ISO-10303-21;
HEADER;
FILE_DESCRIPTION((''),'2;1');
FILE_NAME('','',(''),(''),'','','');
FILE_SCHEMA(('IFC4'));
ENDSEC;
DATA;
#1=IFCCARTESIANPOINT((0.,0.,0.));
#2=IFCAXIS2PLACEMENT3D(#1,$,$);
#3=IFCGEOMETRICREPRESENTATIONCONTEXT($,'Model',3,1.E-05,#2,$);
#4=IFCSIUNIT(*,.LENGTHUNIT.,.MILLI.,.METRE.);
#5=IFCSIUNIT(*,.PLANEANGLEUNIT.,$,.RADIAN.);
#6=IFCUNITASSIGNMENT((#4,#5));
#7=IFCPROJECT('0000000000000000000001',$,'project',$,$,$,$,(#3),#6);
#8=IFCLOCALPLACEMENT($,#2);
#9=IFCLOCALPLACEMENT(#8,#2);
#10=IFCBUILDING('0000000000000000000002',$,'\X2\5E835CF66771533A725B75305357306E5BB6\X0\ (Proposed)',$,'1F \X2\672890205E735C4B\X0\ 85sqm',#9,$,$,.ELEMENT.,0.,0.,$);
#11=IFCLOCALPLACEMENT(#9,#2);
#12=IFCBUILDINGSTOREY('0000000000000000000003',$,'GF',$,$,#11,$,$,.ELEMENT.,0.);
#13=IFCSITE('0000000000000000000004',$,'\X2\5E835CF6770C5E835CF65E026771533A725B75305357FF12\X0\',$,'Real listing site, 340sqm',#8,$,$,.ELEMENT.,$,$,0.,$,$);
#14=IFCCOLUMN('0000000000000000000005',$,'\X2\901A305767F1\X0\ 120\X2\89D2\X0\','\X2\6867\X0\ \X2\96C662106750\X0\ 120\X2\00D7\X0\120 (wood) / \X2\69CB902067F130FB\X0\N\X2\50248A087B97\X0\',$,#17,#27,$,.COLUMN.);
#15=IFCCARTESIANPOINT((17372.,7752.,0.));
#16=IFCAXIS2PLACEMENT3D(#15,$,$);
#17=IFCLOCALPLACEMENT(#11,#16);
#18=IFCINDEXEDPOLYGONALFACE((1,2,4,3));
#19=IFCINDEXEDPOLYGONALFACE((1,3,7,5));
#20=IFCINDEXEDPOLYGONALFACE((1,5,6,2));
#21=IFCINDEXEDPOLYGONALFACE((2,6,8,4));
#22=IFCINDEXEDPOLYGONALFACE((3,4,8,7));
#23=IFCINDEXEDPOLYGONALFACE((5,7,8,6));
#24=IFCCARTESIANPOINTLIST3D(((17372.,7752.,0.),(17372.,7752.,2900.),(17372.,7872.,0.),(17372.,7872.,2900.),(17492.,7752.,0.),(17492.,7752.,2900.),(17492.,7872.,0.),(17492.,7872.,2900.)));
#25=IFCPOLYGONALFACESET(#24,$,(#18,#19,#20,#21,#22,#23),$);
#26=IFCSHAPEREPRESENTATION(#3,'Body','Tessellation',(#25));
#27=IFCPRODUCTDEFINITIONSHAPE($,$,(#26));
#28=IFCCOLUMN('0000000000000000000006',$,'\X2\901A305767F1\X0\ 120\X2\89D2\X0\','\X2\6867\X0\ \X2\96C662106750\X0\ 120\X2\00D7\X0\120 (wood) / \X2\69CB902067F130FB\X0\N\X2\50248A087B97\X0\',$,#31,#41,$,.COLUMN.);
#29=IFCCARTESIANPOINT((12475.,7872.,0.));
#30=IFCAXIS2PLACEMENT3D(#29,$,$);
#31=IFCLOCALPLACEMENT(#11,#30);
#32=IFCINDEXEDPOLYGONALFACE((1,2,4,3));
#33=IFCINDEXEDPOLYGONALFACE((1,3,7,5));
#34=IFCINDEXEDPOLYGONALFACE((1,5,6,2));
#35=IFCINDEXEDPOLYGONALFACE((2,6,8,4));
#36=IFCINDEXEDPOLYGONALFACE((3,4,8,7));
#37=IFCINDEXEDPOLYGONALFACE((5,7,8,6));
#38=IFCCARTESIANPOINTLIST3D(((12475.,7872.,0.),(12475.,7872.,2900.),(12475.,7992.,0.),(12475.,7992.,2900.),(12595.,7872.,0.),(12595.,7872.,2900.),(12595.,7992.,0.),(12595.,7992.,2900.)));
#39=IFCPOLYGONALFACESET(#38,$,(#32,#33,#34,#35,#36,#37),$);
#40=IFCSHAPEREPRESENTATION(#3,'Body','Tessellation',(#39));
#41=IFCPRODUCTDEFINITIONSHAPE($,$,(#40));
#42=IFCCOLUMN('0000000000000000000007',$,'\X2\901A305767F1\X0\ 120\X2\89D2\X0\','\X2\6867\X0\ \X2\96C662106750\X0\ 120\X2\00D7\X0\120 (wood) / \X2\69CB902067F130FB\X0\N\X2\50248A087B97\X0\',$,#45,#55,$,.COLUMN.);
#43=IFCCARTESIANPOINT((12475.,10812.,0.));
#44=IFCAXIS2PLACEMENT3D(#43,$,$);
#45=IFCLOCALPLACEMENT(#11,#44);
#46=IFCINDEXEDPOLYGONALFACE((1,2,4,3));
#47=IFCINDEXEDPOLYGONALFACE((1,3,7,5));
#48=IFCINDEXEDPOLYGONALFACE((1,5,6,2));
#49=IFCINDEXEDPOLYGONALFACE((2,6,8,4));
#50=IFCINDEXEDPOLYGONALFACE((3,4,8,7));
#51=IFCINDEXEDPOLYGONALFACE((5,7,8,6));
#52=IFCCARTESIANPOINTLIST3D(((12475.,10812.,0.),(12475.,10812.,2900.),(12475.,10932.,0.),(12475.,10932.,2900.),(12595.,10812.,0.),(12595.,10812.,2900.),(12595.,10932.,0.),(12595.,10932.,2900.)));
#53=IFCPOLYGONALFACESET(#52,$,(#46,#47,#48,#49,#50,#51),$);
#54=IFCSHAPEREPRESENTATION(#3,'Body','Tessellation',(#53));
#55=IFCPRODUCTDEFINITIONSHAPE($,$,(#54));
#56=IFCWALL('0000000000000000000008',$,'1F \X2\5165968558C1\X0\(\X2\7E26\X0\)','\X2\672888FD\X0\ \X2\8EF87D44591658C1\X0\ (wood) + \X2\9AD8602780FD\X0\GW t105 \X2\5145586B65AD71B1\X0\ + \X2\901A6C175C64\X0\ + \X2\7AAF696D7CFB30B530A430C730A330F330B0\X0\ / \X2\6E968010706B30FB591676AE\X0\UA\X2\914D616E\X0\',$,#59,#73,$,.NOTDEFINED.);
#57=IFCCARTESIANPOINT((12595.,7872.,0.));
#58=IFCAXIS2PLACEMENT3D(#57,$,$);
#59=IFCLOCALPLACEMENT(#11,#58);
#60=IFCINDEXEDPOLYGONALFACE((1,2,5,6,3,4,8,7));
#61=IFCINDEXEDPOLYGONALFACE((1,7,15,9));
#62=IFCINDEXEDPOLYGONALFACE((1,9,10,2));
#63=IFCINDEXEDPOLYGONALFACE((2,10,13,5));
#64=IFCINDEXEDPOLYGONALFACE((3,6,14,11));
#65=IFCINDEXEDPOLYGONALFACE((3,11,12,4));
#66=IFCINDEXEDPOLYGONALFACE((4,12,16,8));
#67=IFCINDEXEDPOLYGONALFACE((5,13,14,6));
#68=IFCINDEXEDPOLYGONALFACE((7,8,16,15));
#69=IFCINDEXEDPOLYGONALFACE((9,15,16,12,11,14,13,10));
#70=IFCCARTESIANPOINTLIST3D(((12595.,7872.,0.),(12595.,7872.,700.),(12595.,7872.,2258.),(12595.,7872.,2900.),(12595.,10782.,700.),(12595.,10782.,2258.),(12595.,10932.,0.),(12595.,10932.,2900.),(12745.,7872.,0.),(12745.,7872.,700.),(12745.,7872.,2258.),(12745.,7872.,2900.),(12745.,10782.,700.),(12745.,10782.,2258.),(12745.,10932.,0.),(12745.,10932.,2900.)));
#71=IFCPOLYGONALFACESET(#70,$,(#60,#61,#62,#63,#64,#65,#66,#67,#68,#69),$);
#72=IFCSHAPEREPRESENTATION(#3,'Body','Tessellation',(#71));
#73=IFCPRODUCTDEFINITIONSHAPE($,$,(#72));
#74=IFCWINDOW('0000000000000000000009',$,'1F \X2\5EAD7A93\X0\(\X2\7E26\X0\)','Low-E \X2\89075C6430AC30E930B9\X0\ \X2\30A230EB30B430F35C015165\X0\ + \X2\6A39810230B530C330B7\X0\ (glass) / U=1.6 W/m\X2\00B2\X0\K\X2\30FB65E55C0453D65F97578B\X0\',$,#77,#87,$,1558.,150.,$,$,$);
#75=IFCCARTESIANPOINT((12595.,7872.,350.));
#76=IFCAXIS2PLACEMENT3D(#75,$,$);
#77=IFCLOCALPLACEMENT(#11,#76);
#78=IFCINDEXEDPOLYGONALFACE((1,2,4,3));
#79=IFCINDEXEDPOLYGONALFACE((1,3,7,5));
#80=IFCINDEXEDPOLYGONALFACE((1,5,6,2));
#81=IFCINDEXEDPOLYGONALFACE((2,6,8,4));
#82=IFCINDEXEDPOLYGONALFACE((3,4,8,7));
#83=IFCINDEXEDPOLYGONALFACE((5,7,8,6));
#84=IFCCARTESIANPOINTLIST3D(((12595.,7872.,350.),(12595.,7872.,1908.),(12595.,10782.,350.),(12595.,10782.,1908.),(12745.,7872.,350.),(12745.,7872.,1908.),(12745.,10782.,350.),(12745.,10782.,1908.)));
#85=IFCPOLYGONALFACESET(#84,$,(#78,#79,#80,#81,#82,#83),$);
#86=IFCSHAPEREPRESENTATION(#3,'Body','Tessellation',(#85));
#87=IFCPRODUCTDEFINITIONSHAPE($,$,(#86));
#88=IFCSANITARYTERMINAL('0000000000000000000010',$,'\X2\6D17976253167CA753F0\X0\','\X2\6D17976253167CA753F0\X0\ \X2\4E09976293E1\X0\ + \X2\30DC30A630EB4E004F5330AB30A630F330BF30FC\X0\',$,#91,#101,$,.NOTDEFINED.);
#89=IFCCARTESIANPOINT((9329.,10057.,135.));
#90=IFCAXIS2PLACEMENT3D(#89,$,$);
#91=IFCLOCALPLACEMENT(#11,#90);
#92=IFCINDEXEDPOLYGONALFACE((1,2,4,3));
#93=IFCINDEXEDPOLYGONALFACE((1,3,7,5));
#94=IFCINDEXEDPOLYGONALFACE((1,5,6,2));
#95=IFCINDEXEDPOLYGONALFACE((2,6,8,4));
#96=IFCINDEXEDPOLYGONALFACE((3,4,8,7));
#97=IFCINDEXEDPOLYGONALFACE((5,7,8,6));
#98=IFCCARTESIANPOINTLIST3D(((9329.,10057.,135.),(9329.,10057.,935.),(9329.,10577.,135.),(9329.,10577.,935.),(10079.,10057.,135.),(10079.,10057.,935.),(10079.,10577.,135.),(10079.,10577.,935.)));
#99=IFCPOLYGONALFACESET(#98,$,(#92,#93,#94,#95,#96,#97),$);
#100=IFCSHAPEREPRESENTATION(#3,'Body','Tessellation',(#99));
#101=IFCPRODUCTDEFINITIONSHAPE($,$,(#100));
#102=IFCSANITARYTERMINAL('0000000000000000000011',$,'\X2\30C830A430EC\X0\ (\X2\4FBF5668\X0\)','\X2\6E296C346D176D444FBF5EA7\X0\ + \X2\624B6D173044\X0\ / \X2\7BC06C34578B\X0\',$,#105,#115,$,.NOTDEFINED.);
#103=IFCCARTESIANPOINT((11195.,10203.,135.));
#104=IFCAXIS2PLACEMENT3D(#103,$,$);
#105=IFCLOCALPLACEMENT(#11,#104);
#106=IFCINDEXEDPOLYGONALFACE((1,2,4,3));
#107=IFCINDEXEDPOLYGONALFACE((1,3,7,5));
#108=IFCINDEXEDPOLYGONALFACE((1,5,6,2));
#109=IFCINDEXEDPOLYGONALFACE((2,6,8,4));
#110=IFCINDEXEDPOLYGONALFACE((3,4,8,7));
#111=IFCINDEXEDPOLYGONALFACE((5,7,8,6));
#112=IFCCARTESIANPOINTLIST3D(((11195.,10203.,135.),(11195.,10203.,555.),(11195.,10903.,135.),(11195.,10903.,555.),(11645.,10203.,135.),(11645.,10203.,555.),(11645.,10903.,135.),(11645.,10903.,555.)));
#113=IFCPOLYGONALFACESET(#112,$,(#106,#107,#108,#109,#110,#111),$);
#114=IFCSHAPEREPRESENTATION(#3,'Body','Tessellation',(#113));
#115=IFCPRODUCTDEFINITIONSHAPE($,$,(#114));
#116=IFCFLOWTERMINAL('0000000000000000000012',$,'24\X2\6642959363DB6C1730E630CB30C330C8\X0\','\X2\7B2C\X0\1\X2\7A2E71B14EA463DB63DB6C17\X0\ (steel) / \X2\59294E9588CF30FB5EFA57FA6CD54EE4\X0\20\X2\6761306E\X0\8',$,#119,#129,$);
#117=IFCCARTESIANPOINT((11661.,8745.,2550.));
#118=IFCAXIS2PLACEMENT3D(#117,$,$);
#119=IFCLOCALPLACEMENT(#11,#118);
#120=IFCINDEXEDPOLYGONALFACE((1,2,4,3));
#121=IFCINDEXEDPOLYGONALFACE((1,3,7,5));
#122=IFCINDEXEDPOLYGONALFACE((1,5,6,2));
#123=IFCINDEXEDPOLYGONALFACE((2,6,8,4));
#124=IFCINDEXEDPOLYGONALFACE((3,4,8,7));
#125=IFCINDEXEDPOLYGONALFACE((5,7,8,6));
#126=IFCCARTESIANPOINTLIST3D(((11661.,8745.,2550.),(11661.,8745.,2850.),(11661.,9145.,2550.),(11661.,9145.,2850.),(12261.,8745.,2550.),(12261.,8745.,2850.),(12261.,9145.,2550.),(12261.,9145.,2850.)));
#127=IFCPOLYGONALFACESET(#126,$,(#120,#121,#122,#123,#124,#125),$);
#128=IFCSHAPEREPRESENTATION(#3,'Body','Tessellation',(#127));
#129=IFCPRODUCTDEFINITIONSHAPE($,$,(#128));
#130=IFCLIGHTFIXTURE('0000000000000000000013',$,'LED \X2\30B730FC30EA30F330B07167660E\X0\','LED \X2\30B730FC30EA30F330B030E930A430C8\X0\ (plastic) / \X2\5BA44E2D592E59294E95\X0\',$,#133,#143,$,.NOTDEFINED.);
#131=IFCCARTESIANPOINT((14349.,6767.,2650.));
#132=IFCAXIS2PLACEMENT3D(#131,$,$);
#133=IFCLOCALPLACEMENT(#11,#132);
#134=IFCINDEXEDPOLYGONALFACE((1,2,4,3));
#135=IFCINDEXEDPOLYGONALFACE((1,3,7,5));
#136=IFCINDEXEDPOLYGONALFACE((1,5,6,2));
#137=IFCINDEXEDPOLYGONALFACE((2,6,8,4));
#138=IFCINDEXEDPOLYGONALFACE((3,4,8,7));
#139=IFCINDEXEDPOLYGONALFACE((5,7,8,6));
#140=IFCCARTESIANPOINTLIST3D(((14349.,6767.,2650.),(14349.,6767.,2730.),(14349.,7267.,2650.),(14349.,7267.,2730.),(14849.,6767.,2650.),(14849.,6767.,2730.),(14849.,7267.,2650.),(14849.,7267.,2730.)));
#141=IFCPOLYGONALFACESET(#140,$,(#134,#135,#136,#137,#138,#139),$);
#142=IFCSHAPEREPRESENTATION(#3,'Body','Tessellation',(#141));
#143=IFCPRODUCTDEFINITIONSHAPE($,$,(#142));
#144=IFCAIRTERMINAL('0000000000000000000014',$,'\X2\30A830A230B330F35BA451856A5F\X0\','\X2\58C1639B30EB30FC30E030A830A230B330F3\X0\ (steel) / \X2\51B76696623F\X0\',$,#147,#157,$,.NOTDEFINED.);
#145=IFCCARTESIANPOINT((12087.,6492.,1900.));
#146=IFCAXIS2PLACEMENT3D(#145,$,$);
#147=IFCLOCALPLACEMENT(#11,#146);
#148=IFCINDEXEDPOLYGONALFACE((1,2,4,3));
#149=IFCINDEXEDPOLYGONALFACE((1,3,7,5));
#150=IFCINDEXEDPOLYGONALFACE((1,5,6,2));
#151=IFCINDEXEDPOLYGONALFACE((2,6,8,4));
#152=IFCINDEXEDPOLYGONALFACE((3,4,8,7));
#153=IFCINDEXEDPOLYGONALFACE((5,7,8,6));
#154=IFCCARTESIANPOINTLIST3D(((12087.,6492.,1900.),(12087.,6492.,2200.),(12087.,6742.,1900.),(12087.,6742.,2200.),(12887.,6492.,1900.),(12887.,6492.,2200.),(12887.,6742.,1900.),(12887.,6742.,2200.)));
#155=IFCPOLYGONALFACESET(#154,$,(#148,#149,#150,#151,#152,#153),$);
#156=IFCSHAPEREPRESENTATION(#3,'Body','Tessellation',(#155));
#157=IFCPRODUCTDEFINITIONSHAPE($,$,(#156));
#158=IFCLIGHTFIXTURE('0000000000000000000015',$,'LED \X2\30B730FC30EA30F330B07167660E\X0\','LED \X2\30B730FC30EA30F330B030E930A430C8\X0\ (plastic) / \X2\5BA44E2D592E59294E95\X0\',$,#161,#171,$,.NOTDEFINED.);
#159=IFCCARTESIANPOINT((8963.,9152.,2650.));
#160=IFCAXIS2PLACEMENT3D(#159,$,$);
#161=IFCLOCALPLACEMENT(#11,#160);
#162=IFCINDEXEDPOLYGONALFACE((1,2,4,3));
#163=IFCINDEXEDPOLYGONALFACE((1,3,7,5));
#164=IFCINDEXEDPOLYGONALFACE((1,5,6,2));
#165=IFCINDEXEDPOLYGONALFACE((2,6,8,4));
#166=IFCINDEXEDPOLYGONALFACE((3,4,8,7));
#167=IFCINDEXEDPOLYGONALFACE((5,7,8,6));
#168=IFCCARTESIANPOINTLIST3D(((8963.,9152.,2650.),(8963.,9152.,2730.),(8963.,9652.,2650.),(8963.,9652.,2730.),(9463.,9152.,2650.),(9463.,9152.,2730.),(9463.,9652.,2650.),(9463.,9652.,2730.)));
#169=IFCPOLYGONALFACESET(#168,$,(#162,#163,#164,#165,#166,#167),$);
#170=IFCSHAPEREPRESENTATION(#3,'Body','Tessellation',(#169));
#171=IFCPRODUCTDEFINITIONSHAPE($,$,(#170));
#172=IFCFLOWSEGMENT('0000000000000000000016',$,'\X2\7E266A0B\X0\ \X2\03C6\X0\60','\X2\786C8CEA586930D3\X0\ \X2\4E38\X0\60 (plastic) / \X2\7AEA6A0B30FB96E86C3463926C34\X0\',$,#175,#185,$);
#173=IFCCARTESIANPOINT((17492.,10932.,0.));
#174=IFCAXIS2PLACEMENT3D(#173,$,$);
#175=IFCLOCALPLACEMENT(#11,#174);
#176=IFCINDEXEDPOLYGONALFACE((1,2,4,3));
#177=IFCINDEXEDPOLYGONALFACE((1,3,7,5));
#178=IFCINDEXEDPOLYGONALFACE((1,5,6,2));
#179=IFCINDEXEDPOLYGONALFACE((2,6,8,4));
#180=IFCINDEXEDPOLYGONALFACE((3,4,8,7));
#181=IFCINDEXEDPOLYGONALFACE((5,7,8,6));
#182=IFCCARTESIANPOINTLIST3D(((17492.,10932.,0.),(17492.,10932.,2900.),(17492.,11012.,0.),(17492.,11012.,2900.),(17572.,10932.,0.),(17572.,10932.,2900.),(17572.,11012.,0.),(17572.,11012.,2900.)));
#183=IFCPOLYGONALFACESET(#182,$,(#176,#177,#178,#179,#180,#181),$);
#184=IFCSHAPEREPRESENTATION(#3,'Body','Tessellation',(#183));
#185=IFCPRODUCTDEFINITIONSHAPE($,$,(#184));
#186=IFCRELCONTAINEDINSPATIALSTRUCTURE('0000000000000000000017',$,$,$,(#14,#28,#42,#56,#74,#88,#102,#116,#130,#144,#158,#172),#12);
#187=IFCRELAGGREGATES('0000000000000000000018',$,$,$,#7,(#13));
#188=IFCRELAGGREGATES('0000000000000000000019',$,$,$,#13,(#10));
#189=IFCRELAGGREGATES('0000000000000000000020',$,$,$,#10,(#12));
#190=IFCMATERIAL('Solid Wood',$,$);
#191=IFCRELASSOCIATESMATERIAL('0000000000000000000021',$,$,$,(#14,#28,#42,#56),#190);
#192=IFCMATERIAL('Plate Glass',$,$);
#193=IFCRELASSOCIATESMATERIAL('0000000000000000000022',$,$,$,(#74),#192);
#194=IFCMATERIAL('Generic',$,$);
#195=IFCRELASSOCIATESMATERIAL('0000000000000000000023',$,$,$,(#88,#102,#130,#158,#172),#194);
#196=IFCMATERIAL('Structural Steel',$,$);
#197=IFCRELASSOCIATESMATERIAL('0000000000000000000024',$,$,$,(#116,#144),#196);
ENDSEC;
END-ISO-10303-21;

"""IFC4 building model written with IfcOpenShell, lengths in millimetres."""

from ifc_helpers import new_model, si_unit, frame, frame_2d, origin, place, context, project, spatial, rectangle, extrude, material, element, fill, save


model = new_model("IFC4")

# Units and contexts
model_context = context("Model", 3, precision=1e-05, world=origin())
ifc_project = project(units=[si_unit("LENGTHUNIT", "METRE", prefix="MILLI"), si_unit("PLANEANGLEUNIT", "RADIAN")], contexts=[model_context])

# Site, building, storey
site_placement = place(None, origin())
site = spatial("IfcSite", under=ifc_project, at=site_placement, Name="広島県広島市東区牛田南２", ObjectType="Real listing site, 340sqm", CompositionType="ELEMENT", RefElevation=0.0)
building_placement = place(site_placement, origin())
building = spatial("IfcBuilding", under=site, at=building_placement, Name="広島東区牛田南の家 (Proposed)", ObjectType="1F 木造平屋 85sqm", CompositionType="ELEMENT", ElevationOfRefHeight=0.0, ElevationOfTerrain=0.0)
storey_placement = place(building_placement, origin())
storey = spatial("IfcBuildingStorey", under=building, at=storey_placement, Name="GF", CompositionType="ELEMENT", Elevation=0.0)

# Columns
ifc_material_1 = material(Name="Solid Wood")
column_1_placement = place(storey_placement, frame((17372.0, 7752.0, 0.0)))
element("IfcColumn", 1, at=column_1_placement, inside=storey, material=ifc_material_1, Name="通し柱 120角", Description="桧 集成材 120×120 (wood) / 構造柱・N値計算", PredefinedType="COLUMN", context=model_context, shape_type="SweptSolid", body=[
    extrude(rectangle(XDim=120.0, YDim=120.0, at=frame_2d((60.0, 60.0))), frame((17372.0, 7752.0, 0.0)), (0.0, 0.0, 1.0), 2900.0),
])
column_2_placement = place(storey_placement, frame((12475.0, 7872.0, 0.0)))
element("IfcColumn", 2, at=column_2_placement, inside=storey, material=ifc_material_1, Name="通し柱 120角", Description="桧 集成材 120×120 (wood) / 構造柱・N値計算", PredefinedType="COLUMN", context=model_context, shape_type="SweptSolid", body=[
    extrude(rectangle(XDim=120.0, YDim=120.0, at=frame_2d((60.0, 60.0))), frame((12475.0, 7872.0, 0.0)), (0.0, 0.0, 1.0), 2900.0),
])
column_3_placement = place(storey_placement, frame((12475.0, 10812.0, 0.0)))
element("IfcColumn", 3, at=column_3_placement, inside=storey, material=ifc_material_1, Name="通し柱 120角", Description="桧 集成材 120×120 (wood) / 構造柱・N値計算", PredefinedType="COLUMN", context=model_context, shape_type="SweptSolid", body=[
    extrude(rectangle(XDim=120.0, YDim=120.0, at=frame_2d((60.0, 60.0))), frame((12475.0, 10812.0, 0.0)), (0.0, 0.0, 1.0), 2900.0),
])

# Wall, opening, window
wall_1_placement = place(storey_placement, frame((12595.0, 7872.0, 0.0)))
wall_1 = element("IfcWall", 4, at=wall_1_placement, inside=storey, material=ifc_material_1, Name="1F 入隅壁(縦)", Description="木製 軸組外壁 (wood) + 高性能GW t105 充填断熱 + 通気層 + 窯業系サイディング / 準耐火・外皮UA配慮", PredefinedType="NOTDEFINED", context=model_context, shape_type="SweptSolid", body=[
    extrude(rectangle(XDim=150.0, YDim=3060.0, at=frame_2d((75.0, 1530.0))), frame((12595.0, 7872.0, 0.0)), (0.0, 0.0, 1.0), 2900.0),
])
opening_placement = place(storey_placement, frame((12595.0, 7872.0, 350.0)))
opening = element("IfcOpeningElement", 5, at=opening_placement, cuts=wall_1, PredefinedType="NOTDEFINED", context=model_context, shape_type="SweptSolid", body=[
    extrude(rectangle(XDim=150.0, YDim=2910.0, at=frame_2d((75.0, 1455.0))), frame((12595.0, 7872.0, 350.0)), (0.0, 0.0, 1.0), 1558.0),
])
ifc_material_2 = material(Name="Plate Glass")
window_placement = place(storey_placement, frame((12595.0, 7872.0, 350.0)))
window = element("IfcWindow", 6, at=window_placement, inside=storey, material=ifc_material_2, Name="1F 庭窓(縦)", Description="Low-E 複層ガラス アルゴン封入 + 樹脂サッシ (glass) / U=1.6 W/m²K・日射取得型", OverallHeight=1558.0, OverallWidth=150.0, context=model_context, shape_type="SweptSolid", body=[
    extrude(rectangle(XDim=150.0, YDim=2910.0, at=frame_2d((75.0, 1455.0))), frame((12595.0, 7872.0, 350.0)), (0.0, 0.0, 1.0), 1558.0),
])
fill(opening, window)

# Sanitary terminals
ifc_material_3 = material(Name="Generic")
sanitary_terminal_1_placement = place(storey_placement, frame((9329.0, 10057.0, 135.0)))
element("IfcSanitaryTerminal", 7, at=sanitary_terminal_1_placement, inside=storey, material=ifc_material_3, Name="洗面化粧台", Description="洗面化粧台 三面鏡 + ボウル一体カウンター", PredefinedType="NOTDEFINED", context=model_context, shape_type="SweptSolid", body=[
    extrude(rectangle(XDim=750.0, YDim=520.0, at=frame_2d((375.0, 260.0))), frame((9329.0, 10057.0, 135.0)), (0.0, 0.0, 1.0), 800.0),
])
sanitary_terminal_2_placement = place(storey_placement, frame((11195.0, 10203.0, 135.0)))
element("IfcSanitaryTerminal", 8, at=sanitary_terminal_2_placement, inside=storey, material=ifc_material_3, Name="トイレ (便器)", Description="温水洗浄便座 + 手洗い / 節水型", PredefinedType="NOTDEFINED", context=model_context, shape_type="SweptSolid", body=[
    extrude(rectangle(XDim=450.0, YDim=700.0, at=frame_2d((225.0, 350.0))), frame((11195.0, 10203.0, 135.0)), (0.0, 0.0, 1.0), 420.0),
])

# Flow terminal
ifc_material_4 = material(Name="Structural Steel")
flow_terminal_placement = place(storey_placement, frame((11661.0, 8745.0, 2550.0)))
element("IfcFlowTerminal", 9, at=flow_terminal_placement, inside=storey, material=ifc_material_4, Name="24時間換気ユニット", Description="第1種熱交換換気 (steel) / 天井裏・建基法令20条の8", context=model_context, shape_type="SweptSolid", body=[
    extrude(rectangle(XDim=600.0, YDim=400.0, at=frame_2d((300.0, 200.0))), frame((11661.0, 8745.0, 2550.0)), (0.0, 0.0, 1.0), 300.0),
])

# Light fixture
light_fixture_1_placement = place(storey_placement, frame((14349.0, 6767.0, 2650.0)))
element("IfcLightFixture", 10, at=light_fixture_1_placement, inside=storey, material=ifc_material_3, Name="LED シーリング照明", Description="LED シーリングライト (plastic) / 室中央天井", PredefinedType="NOTDEFINED", context=model_context, shape_type="SweptSolid", body=[
    extrude(rectangle(XDim=500.0, YDim=500.0, at=frame_2d((250.0, 250.0))), frame((14349.0, 6767.0, 2650.0)), (0.0, 0.0, 1.0), 80.0),
])

# Air terminal
air_terminal_placement = place(storey_placement, frame((12087.0, 6492.0, 1900.0)))
element("IfcAirTerminal", 11, at=air_terminal_placement, inside=storey, material=ifc_material_4, Name="エアコン室内機", Description="壁掛ルームエアコン (steel) / 冷暖房", PredefinedType="NOTDEFINED", context=model_context, shape_type="SweptSolid", body=[
    extrude(rectangle(XDim=800.0, YDim=250.0, at=frame_2d((400.0, 125.0))), frame((12087.0, 6492.0, 1900.0)), (0.0, 0.0, 1.0), 300.0),
])

# Light fixture
light_fixture_2_placement = place(storey_placement, frame((8963.0, 9152.0, 2650.0)))
element("IfcLightFixture", 12, at=light_fixture_2_placement, inside=storey, material=ifc_material_3, Name="LED シーリング照明", Description="LED シーリングライト (plastic) / 室中央天井", PredefinedType="NOTDEFINED", context=model_context, shape_type="SweptSolid", body=[
    extrude(rectangle(XDim=500.0, YDim=500.0, at=frame_2d((250.0, 250.0))), frame((8963.0, 9152.0, 2650.0)), (0.0, 0.0, 1.0), 80.0),
])

# Flow segment
flow_segment_placement = place(storey_placement, frame((17492.0, 10932.0, 0.0)))
element("IfcFlowSegment", 13, at=flow_segment_placement, inside=storey, material=ifc_material_3, Name="縦樋 φ60", Description="硬質塩ビ 丸60 (plastic) / 竪樋・雨水排水", context=model_context, shape_type="SweptSolid", body=[
    extrude(rectangle(XDim=80.0, YDim=80.0, at=frame_2d((40.0, 40.0))), frame((17492.0, 10932.0, 0.0)), (0.0, 0.0, 1.0), 2900.0),
])

save(model, "model.ifc")
